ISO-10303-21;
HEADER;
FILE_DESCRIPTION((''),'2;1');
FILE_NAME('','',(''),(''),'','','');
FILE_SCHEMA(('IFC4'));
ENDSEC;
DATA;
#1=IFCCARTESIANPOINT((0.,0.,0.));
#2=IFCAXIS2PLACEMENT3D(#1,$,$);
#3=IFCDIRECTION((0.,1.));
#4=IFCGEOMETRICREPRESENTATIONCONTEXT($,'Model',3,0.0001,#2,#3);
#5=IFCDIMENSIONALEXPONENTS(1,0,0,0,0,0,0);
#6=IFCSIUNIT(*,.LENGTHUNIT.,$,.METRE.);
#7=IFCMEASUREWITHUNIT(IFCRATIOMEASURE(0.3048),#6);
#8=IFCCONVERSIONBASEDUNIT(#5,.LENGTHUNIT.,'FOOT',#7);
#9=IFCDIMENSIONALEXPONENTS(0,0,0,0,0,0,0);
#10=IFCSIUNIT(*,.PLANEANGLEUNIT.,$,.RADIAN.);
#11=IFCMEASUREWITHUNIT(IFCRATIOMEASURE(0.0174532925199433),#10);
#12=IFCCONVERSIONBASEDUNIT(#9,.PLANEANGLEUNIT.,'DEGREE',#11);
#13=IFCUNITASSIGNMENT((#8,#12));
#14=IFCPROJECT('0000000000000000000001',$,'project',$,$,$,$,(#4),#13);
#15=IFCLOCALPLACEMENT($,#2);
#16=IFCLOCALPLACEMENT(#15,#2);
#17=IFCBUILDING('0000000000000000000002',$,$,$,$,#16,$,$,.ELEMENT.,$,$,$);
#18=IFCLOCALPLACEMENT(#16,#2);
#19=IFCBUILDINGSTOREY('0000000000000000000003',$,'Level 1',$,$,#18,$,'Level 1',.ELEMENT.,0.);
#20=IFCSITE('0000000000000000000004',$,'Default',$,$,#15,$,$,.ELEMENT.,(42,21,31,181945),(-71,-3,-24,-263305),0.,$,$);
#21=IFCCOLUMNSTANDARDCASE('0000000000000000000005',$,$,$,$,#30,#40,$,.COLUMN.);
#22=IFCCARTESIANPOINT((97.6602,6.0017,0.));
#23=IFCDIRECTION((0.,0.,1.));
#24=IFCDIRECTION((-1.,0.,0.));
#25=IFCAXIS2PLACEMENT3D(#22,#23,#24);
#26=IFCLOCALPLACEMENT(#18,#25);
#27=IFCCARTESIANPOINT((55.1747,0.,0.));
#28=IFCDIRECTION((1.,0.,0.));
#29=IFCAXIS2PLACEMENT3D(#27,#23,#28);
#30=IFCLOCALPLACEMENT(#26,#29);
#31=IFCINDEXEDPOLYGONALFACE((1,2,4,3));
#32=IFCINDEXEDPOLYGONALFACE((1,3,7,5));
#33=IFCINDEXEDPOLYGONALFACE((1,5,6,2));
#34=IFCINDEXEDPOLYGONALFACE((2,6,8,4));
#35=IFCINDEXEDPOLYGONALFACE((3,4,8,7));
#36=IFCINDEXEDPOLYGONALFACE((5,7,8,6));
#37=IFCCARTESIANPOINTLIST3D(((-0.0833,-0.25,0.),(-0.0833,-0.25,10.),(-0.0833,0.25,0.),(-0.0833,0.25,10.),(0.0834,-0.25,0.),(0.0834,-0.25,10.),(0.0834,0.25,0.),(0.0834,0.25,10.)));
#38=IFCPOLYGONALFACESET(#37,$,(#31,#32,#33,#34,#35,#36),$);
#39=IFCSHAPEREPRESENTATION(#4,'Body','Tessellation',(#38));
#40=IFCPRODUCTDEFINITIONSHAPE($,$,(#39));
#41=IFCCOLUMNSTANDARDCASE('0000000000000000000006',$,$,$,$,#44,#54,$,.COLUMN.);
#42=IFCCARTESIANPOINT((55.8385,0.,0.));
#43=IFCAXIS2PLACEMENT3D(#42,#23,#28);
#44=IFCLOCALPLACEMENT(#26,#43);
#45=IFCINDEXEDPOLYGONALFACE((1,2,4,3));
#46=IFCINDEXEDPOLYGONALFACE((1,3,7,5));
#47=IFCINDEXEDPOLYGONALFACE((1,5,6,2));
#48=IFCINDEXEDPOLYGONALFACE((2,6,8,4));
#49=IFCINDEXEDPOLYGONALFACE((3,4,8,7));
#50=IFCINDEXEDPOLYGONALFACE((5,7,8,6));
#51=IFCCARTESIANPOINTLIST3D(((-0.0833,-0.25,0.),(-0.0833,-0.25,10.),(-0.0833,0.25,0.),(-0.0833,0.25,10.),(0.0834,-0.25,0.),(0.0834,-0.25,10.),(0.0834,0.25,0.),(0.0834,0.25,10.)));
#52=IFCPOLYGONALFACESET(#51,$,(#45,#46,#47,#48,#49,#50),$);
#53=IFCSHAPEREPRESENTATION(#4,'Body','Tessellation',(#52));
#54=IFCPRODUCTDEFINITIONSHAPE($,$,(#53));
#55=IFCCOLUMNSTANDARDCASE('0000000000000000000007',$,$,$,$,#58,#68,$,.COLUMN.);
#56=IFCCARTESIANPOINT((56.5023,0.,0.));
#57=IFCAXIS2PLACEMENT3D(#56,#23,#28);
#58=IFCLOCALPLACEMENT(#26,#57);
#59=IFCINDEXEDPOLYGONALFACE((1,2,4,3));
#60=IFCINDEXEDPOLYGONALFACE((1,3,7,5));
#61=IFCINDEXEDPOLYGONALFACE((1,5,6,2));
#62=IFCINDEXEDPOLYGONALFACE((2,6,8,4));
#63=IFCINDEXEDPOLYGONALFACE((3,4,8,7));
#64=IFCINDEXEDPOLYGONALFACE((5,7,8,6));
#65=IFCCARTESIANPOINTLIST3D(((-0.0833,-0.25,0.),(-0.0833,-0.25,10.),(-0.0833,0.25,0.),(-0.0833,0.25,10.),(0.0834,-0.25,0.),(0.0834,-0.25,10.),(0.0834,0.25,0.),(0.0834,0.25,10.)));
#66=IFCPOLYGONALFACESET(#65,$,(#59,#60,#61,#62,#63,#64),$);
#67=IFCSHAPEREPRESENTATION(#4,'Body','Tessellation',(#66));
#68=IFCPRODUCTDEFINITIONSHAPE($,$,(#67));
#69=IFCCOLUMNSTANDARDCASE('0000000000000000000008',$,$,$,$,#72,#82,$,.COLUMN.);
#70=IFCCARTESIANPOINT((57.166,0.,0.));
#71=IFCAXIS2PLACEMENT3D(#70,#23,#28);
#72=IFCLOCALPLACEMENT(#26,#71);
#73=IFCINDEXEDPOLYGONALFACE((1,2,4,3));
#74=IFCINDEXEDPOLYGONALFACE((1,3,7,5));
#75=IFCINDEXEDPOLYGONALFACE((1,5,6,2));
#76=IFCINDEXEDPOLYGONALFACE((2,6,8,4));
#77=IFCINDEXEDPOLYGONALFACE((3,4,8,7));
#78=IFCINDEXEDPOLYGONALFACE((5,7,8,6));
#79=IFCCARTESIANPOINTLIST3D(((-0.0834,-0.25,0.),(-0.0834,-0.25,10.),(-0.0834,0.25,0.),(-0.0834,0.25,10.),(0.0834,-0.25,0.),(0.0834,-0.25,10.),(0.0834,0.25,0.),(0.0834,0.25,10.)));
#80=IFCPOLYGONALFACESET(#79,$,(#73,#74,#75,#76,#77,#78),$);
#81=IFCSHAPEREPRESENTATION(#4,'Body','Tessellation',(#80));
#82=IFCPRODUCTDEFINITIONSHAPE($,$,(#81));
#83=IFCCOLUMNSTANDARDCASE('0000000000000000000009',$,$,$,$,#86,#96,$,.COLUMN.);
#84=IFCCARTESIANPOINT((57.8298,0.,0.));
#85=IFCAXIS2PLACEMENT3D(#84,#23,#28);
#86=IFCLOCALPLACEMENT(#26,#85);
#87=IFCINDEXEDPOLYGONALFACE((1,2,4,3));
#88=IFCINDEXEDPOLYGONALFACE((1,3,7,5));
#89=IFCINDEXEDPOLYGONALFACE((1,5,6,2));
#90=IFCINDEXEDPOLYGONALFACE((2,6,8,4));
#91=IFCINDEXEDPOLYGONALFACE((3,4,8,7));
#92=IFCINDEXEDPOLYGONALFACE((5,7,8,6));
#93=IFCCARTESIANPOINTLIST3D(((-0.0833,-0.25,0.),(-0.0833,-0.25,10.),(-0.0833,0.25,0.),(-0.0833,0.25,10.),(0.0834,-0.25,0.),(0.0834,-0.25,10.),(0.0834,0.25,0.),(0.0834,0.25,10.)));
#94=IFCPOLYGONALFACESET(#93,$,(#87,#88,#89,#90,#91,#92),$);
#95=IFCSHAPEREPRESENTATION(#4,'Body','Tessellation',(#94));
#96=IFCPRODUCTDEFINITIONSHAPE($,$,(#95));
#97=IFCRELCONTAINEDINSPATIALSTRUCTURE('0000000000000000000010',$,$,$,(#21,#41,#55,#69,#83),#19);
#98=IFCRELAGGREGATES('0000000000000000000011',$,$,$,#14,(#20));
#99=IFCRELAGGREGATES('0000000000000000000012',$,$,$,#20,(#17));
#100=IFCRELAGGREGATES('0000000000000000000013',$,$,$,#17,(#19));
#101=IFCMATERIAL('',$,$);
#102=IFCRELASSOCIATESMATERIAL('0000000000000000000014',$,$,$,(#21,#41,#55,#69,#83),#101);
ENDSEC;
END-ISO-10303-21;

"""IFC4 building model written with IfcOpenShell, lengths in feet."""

from ifc_helpers import new_model, entity, si_unit, converted_unit, direction, frame, origin, place, context, project, spatial, rectangle, extrude, material, element, save


model = new_model("IFC4")

# Units and contexts
model_context = context("Model", 3, precision=0.0001, world=origin(), true_north=direction((0.0, 1.0)))
ifc_project = project(units=[converted_unit("LENGTHUNIT", "FOOT", entity("IfcRatioMeasure", 0.3048), si_unit("LENGTHUNIT", "METRE"), dimensions=[1, 0, 0, 0, 0, 0, 0]), converted_unit("PLANEANGLEUNIT", "DEGREE", entity("IfcRatioMeasure", 0.0174532925199433), si_unit("PLANEANGLEUNIT", "RADIAN"), dimensions=[0, 0, 0, 0, 0, 0, 0])], contexts=[model_context])

# Site, building, storey
site_placement = place(None, origin())
site = spatial("IfcSite", under=ifc_project, at=site_placement, Name="Default", CompositionType="ELEMENT", RefLatitude=(42, 21, 31, 181945), RefLongitude=(-71, -3, -24, -263305), RefElevation=0.0)
building_placement = place(site_placement, origin())
building = spatial("IfcBuilding", under=site, at=building_placement, CompositionType="ELEMENT")
storey_placement = place(building_placement, origin())
storey = spatial("IfcBuildingStorey", under=building, at=storey_placement, Name="Level 1", LongName="Level 1", CompositionType="ELEMENT", Elevation=0.0)

# Columns
ifc_material = material(Name="")
placement = place(storey_placement, frame((97.6602, 6.0017, 0.0), z_axis=(0.0, 0.0, 1.0), x_axis=(-1.0, 0.0, 0.0)))
for number, where, z_axis, x_axis in (
    (1, (55.1747, 0.0, 0.0), (0.0, 0.0, 1.0), (1.0, 0.0, 0.0)),
    (2, (55.8385, 0.0, 0.0), (0.0, 0.0, 1.0), (1.0, 0.0, 0.0)),
    (3, (56.5023, 0.0, 0.0), (0.0, 0.0, 1.0), (1.0, 0.0, 0.0)),
    (4, (57.166, 0.0, 0.0), (0.0, 0.0, 1.0), (1.0, 0.0, 0.0)),
    (5, (57.8298, 0.0, 0.0), (0.0, 0.0, 1.0), (1.0, 0.0, 0.0)),
):
    element("IfcColumnStandardCase", number, at=place(placement, frame(where, z_axis=z_axis, x_axis=x_axis)), inside=storey, material=ifc_material, PredefinedType="COLUMN", context=model_context, shape_type="SweptSolid", body=[
        extrude(rectangle(XDim=0.1667, YDim=0.5), origin(), (0.0, 0.0, 1.0), 10.0),
    ])

save(model, "model.ifc")
